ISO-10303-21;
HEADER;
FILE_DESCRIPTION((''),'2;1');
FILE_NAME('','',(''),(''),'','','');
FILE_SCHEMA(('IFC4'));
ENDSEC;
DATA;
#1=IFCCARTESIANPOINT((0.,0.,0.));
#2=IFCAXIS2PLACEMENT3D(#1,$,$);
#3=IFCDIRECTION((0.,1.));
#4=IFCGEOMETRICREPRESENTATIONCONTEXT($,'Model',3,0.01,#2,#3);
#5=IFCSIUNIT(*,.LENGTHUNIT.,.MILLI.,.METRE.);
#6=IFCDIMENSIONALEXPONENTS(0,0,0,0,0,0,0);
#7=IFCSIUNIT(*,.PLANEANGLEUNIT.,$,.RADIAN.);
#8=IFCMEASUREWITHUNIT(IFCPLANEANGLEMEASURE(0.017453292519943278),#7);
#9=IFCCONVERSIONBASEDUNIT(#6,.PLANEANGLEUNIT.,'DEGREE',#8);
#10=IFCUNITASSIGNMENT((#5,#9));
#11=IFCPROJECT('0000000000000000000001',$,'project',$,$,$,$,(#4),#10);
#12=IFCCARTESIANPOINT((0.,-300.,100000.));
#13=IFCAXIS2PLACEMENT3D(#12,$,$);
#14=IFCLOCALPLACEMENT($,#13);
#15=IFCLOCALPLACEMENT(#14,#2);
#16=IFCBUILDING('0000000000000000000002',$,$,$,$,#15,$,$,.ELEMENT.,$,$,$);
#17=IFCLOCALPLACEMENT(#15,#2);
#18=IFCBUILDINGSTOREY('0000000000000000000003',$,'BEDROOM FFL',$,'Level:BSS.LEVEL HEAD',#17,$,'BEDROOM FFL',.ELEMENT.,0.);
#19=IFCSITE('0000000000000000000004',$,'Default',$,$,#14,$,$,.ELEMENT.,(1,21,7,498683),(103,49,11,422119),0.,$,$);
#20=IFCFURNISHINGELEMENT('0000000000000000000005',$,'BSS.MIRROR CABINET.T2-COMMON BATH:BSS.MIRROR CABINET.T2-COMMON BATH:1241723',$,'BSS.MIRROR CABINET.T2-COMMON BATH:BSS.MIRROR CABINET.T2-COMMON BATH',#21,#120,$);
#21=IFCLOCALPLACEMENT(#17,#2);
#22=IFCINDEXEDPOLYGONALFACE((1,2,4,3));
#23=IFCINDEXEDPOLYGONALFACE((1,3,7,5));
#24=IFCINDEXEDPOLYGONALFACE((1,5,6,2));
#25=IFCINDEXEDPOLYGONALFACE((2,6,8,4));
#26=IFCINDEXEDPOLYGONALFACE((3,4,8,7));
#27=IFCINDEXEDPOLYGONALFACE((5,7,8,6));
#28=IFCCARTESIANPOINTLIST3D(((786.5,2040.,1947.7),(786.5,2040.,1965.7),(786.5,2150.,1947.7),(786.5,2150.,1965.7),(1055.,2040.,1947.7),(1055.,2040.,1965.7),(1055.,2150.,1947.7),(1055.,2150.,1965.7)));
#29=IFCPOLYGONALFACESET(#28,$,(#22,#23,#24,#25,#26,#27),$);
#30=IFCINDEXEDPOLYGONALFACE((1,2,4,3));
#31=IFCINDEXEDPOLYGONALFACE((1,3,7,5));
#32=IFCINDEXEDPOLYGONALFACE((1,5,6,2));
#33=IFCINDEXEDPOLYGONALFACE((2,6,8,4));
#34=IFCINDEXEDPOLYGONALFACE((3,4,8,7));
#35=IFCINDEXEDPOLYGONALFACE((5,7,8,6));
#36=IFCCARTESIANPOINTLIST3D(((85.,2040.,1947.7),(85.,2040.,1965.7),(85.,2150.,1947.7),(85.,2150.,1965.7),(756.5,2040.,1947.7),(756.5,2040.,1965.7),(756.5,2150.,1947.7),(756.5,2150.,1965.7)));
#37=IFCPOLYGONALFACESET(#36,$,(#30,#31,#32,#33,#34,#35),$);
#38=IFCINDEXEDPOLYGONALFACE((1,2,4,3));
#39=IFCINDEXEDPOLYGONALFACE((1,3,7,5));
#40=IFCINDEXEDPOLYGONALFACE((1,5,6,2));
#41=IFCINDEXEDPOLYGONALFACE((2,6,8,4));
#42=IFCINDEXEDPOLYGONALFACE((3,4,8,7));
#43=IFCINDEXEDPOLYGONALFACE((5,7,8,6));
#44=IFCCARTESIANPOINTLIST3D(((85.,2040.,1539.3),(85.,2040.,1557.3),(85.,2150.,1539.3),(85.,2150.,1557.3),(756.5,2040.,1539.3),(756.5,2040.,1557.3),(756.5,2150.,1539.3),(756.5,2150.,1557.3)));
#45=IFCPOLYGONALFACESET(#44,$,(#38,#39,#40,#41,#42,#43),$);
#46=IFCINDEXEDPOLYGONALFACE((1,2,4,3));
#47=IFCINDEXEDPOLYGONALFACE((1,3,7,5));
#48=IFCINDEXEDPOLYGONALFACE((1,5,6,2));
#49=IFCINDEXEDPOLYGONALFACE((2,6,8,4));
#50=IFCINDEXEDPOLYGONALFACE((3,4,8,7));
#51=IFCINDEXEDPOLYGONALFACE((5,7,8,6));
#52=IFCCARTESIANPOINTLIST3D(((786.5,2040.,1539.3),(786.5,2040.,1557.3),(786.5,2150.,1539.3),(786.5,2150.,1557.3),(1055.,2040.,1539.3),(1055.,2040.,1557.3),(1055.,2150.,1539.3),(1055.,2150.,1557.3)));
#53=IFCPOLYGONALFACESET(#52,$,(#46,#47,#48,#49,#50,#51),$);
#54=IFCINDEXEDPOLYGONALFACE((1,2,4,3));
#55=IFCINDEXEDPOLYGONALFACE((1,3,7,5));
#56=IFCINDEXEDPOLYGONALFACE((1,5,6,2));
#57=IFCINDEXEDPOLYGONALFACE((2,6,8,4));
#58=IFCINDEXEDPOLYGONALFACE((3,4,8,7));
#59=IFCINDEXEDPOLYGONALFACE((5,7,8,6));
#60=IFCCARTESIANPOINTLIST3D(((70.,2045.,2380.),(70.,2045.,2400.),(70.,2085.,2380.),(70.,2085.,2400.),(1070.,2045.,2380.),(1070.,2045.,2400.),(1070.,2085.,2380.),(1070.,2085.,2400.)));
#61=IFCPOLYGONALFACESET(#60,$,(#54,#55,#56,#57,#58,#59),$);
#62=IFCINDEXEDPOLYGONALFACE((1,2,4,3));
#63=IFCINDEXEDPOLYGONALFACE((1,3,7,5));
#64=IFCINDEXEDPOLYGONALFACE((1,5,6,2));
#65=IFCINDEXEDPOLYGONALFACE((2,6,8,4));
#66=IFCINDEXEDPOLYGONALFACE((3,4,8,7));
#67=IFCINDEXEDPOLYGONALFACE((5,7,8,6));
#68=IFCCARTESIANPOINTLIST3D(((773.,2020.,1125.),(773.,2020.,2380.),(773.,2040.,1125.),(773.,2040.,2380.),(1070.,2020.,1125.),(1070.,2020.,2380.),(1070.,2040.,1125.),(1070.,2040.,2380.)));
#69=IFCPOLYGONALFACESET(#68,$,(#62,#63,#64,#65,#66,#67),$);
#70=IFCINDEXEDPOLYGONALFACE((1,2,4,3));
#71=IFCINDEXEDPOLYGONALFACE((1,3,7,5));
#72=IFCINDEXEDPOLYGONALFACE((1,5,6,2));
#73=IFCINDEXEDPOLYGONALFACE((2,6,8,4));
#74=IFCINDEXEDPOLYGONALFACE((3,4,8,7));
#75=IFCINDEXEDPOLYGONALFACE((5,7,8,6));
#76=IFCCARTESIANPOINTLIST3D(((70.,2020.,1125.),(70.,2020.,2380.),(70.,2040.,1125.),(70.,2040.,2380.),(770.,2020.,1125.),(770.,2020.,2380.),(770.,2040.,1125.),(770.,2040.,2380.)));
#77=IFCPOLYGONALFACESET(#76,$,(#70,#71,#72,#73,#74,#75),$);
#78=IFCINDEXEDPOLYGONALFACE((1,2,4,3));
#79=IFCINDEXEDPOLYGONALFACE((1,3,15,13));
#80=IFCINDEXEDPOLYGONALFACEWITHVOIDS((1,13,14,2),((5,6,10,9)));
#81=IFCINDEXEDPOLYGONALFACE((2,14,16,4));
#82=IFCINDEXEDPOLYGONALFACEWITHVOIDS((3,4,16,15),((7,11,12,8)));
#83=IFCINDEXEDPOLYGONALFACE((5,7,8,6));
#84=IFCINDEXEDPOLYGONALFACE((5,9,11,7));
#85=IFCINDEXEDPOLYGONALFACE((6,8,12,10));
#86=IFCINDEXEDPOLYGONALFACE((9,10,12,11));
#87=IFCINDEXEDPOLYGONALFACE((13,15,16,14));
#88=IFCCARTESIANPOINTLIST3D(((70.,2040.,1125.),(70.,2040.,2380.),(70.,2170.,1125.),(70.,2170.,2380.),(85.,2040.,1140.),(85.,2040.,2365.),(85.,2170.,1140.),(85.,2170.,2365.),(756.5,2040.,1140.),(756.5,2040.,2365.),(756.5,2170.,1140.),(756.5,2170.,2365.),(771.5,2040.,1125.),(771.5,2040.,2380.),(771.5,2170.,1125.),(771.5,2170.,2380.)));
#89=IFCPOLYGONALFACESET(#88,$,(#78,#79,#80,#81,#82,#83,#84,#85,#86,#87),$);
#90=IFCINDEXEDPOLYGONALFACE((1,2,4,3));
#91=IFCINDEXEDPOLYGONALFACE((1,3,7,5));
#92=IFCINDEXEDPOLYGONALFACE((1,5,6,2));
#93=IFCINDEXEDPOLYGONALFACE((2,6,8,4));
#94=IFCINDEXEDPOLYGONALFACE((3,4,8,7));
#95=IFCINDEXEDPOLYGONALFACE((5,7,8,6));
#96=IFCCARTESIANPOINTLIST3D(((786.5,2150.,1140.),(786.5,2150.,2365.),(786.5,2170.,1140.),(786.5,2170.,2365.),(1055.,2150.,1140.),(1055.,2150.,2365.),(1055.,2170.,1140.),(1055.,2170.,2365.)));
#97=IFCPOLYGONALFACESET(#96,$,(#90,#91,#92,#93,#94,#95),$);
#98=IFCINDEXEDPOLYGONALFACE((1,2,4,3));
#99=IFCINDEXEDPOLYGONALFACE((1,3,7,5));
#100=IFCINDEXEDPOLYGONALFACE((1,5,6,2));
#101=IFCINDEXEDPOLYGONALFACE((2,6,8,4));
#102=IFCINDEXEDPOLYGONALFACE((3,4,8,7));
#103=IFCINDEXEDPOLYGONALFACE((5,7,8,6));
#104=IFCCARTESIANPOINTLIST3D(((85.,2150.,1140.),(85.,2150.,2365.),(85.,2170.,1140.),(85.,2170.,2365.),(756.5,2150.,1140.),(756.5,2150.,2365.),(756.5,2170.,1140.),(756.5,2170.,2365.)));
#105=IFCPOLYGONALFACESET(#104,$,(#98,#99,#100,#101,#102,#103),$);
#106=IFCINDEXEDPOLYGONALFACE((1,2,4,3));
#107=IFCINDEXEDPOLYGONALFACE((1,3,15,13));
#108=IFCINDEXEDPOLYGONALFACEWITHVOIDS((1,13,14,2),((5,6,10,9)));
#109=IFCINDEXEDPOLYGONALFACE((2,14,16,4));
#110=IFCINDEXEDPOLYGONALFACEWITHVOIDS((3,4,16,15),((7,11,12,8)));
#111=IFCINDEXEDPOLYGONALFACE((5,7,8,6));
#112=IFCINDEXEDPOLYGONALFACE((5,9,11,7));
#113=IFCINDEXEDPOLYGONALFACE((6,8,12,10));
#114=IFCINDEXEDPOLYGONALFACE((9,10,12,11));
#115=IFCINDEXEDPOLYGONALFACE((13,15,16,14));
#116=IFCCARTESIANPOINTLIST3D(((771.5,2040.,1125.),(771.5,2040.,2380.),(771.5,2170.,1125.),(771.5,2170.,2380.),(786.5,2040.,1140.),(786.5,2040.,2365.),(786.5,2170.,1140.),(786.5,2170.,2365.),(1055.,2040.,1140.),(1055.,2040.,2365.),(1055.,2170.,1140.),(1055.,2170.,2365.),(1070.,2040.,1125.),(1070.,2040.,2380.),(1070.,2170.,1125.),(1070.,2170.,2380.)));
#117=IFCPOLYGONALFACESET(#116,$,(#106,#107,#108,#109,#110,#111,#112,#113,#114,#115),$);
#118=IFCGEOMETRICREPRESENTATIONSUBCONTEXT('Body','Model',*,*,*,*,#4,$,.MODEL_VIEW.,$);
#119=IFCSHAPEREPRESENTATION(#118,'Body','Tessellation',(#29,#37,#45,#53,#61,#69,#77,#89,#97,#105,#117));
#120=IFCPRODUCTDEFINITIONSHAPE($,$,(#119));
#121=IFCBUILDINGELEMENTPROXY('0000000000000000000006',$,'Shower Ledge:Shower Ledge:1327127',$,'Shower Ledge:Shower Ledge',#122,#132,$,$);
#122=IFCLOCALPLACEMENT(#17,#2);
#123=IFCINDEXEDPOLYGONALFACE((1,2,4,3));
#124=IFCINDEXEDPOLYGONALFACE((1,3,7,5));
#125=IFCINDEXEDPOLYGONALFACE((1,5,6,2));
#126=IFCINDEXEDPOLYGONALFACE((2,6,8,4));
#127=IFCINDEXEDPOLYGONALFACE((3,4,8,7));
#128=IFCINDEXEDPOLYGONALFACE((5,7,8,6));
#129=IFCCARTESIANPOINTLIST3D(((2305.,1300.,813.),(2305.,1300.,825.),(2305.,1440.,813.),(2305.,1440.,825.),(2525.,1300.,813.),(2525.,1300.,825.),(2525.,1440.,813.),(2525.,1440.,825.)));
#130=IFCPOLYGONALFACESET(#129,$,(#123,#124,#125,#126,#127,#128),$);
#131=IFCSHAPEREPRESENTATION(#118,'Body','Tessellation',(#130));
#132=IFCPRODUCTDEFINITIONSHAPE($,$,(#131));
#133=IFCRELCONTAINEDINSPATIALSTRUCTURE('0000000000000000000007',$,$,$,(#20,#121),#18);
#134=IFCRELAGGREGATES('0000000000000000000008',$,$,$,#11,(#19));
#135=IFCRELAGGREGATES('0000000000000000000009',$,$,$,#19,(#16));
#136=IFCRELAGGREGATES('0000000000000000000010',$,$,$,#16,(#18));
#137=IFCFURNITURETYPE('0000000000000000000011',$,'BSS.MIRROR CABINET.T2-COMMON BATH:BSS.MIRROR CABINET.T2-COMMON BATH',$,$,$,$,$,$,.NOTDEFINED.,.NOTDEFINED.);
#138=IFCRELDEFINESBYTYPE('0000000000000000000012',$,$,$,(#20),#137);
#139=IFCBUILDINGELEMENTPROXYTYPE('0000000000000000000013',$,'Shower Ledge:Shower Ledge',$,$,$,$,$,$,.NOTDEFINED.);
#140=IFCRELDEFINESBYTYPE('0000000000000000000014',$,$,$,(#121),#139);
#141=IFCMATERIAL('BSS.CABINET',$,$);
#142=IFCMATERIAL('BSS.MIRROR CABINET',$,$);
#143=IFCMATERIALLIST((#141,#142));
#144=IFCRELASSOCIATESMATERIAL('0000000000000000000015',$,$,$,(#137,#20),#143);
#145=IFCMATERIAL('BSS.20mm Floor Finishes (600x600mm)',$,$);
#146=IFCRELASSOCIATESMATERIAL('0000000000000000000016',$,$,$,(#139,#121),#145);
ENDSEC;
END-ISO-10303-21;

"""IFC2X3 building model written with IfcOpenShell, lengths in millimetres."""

from ifc_helpers import new_model, entity, si_unit, converted_unit, direction, frame, frame_2d, origin, origin_2d_with_axis, place, context, subcontext, project, spatial, polyline, rectangle, outline, extrude, source, transform, mapped, material, material_list, type_object, type_shapes, element, save


model = new_model("IFC2X3")

# Units and contexts
model_context = context("Model", 3, precision=0.01, world=origin(), true_north=direction((0.0, 1.0)))
body_context = subcontext(model_context, "Body", "Model", "MODEL_VIEW")
ifc_project = project(units=[si_unit("LENGTHUNIT", "METRE", prefix="MILLI"), converted_unit("PLANEANGLEUNIT", "DEGREE", entity("IfcPlaneAngleMeasure", 0.017453292519943278), si_unit("PLANEANGLEUNIT", "RADIAN"), dimensions=[0, 0, 0, 0, 0, 0, 0])], contexts=[model_context])

# Site, building, storey
site_placement = place(None, frame((0.0, -300.0, 100000.0)))
site = spatial("IfcSite", under=ifc_project, at=site_placement, Name="Default", CompositionType="ELEMENT", RefLatitude=(1, 21, 7, 498683), RefLongitude=(103, 49, 11, 422119), RefElevation=0.0)
building_placement = place(site_placement, origin())
building = spatial("IfcBuilding", under=site, at=building_placement, CompositionType="ELEMENT")
storey_placement = place(building_placement, origin())
storey = spatial("IfcBuildingStorey", under=building, at=storey_placement, Name="BEDROOM FFL", ObjectType="Level:BSS.LEVEL HEAD", LongName="BEDROOM FFL", CompositionType="ELEMENT", Elevation=0.0)

# Shared definitions
ifc_material_1 = material(Name="BSS.20mm Floor Finishes (600x600mm)")

# Furnishing element
ifc_material_2 = material(Name="BSS.CABINET")
ifc_material_3 = material(Name="BSS.MIRROR CABINET")
ifc_material_list = material_list([ifc_material_2, ifc_material_3])
furniture_type = type_object("IfcFurnitureType", Name="BSS.MIRROR CABINET.T2-COMMON BATH:BSS.MIRROR CABINET.T2-COMMON BATH", AssemblyPlace="NOTDEFINED", material=ifc_material_list)
shared_shape_1 = source(origin(), body_context, "Body", "SweptSolid", [
    extrude(rectangle(XDim=110.0, YDim=268.5, at=origin_2d_with_axis()), frame((149.3, -75.0, 822.7), z_axis=(0.0, 0.0, 1.0), x_axis=(0.0, 1.0, 0.0)), (0.0, 0.0, 1.0), 18.0),
    extrude(rectangle(XDim=110.0, YDim=671.5, at=origin_2d_with_axis()), frame((-350.8, -75.0, 822.7), z_axis=(0.0, 0.0, 1.0), x_axis=(0.0, 1.0, 0.0)), (0.0, 0.0, 1.0), 18.0),
    extrude(rectangle(XDim=110.0, YDim=671.5, at=origin_2d_with_axis()), frame((-350.8, -75.0, 414.3), z_axis=(0.0, 0.0, 1.0), x_axis=(0.0, 1.0, 0.0)), (0.0, 0.0, 1.0), 18.0),
    extrude(rectangle(XDim=110.0, YDim=268.5, at=origin_2d_with_axis()), frame((149.3, -75.0, 414.3), z_axis=(0.0, 0.0, 1.0), x_axis=(0.0, 1.0, 0.0)), (0.0, 0.0, 1.0), 18.0),
    extrude(rectangle(XDim=1000.0, YDim=40.0, at=origin_2d_with_axis()), frame((-201.5, -105.0, 1255.0), z_axis=(0.0, 0.0, 1.0), x_axis=(-1.0, 0.0, 0.0)), (0.0, 0.0, 1.0), 20.0),
    extrude(rectangle(XDim=20.0, YDim=297.0, at=frame_2d((0.0, 0.0), x_axis=(1.0, 0.0))), frame((150.0, -140.0, 0.0), z_axis=(0.0, 0.0, 1.0), x_axis=(0.0, 1.0, 0.0)), (0.0, 0.0, 1.0), 1255.0),
    extrude(rectangle(XDim=20.0, YDim=700.0, at=frame_2d((0.0, 0.0), x_axis=(1.0, 0.0))), frame((-351.5, -140.0, 0.0), z_axis=(0.0, 0.0, 1.0), x_axis=(0.0, 1.0, 0.0)), (0.0, 0.0, 1.0), 1255.0),
    extrude(outline(polyline([(-350.7, -627.5), (350.7, -627.5), (350.7, 627.5), (-350.7, 627.5), (-350.7, -627.5)]), holes=[polyline([(-335.8, 612.5), (335.7, 612.5), (335.7, -612.5), (-335.8, -612.5), (-335.8, 612.5)])]), frame((-350.8, -130.0, 627.5), z_axis=(0.0, 1.0, 0.0), x_axis=(1.0, 0.0, 0.0)), (0.0, 0.0, 1.0), 130.0),
    extrude(rectangle(XDim=20.0, YDim=268.5, at=origin_2d_with_axis()), frame((149.3, -10.0, 15.0), z_axis=(0.0, 0.0, 1.0), x_axis=(0.0, 1.0, 0.0)), (0.0, 0.0, 1.0), 1225.0),
    extrude(rectangle(XDim=20.0, YDim=671.5, at=origin_2d_with_axis()), frame((-350.8, -10.0, 15.0), z_axis=(0.0, 0.0, 1.0), x_axis=(0.0, 1.0, 0.0)), (0.0, 0.0, 1.0), 1225.0),
    extrude(outline(polyline([(-149.2, -627.5), (149.2, -627.5), (149.2, 627.5), (-149.2, 627.5), (-149.2, -627.5)]), holes=[polyline([(134.2, 612.5), (134.2, -612.5), (-134.2, -612.5), (-134.2, 612.5), (134.2, 612.5)])]), frame((149.3, -130.0, 627.5), z_axis=(0.0, 1.0, 0.0), x_axis=(-1.0, 0.0, 0.0)), (0.0, 0.0, 1.0), 130.0),
])
type_shapes(furniture_type, [shared_shape_1])
furnishing_placement = place(storey_placement, frame((771.5, 2170.0, 1125.0)))
element("IfcFurnishingElement", 1, at=furnishing_placement, inside=storey, type_object=furniture_type, material=ifc_material_list, Name="BSS.MIRROR CABINET.T2-COMMON BATH:BSS.MIRROR CABINET.T2-COMMON BATH:1241723", ObjectType="BSS.MIRROR CABINET.T2-COMMON BATH:BSS.MIRROR CABINET.T2-COMMON BATH", context=body_context, shape_type="MappedRepresentation", body=[
    mapped(shared_shape_1, transform((0.0, 0.0, 0.0), scale=1.0)),
])

# Building element proxy
building_element_proxy_type = type_object("IfcBuildingElementProxyType", Name="Shower Ledge:Shower Ledge", PredefinedType="NOTDEFINED", material=ifc_material_1)
shared_shape_2 = source(origin(), body_context, "Body", "SweptSolid", [
    extrude(rectangle(XDim=140.0, YDim=220.0, at=frame_2d((0.0, 0.0), x_axis=(1.0, 0.0))), frame((2415.0, 1370.0, 813.0), z_axis=(0.0, 0.0, 1.0), x_axis=(0.0, -1.0, 0.0)), (0.0, 0.0, 1.0), 12.0),
])
type_shapes(building_element_proxy_type, [shared_shape_2])
proxy_placement = place(storey_placement, origin())
element("IfcBuildingElementProxy", 2, at=proxy_placement, inside=storey, type_object=building_element_proxy_type, material=ifc_material_1, Name="Shower Ledge:Shower Ledge:1327127", ObjectType="Shower Ledge:Shower Ledge", context=body_context, shape_type="MappedRepresentation", body=[
    mapped(shared_shape_2, transform((0.0, 0.0, 0.0), scale=1.0)),
])

save(model, "model.ifc")
